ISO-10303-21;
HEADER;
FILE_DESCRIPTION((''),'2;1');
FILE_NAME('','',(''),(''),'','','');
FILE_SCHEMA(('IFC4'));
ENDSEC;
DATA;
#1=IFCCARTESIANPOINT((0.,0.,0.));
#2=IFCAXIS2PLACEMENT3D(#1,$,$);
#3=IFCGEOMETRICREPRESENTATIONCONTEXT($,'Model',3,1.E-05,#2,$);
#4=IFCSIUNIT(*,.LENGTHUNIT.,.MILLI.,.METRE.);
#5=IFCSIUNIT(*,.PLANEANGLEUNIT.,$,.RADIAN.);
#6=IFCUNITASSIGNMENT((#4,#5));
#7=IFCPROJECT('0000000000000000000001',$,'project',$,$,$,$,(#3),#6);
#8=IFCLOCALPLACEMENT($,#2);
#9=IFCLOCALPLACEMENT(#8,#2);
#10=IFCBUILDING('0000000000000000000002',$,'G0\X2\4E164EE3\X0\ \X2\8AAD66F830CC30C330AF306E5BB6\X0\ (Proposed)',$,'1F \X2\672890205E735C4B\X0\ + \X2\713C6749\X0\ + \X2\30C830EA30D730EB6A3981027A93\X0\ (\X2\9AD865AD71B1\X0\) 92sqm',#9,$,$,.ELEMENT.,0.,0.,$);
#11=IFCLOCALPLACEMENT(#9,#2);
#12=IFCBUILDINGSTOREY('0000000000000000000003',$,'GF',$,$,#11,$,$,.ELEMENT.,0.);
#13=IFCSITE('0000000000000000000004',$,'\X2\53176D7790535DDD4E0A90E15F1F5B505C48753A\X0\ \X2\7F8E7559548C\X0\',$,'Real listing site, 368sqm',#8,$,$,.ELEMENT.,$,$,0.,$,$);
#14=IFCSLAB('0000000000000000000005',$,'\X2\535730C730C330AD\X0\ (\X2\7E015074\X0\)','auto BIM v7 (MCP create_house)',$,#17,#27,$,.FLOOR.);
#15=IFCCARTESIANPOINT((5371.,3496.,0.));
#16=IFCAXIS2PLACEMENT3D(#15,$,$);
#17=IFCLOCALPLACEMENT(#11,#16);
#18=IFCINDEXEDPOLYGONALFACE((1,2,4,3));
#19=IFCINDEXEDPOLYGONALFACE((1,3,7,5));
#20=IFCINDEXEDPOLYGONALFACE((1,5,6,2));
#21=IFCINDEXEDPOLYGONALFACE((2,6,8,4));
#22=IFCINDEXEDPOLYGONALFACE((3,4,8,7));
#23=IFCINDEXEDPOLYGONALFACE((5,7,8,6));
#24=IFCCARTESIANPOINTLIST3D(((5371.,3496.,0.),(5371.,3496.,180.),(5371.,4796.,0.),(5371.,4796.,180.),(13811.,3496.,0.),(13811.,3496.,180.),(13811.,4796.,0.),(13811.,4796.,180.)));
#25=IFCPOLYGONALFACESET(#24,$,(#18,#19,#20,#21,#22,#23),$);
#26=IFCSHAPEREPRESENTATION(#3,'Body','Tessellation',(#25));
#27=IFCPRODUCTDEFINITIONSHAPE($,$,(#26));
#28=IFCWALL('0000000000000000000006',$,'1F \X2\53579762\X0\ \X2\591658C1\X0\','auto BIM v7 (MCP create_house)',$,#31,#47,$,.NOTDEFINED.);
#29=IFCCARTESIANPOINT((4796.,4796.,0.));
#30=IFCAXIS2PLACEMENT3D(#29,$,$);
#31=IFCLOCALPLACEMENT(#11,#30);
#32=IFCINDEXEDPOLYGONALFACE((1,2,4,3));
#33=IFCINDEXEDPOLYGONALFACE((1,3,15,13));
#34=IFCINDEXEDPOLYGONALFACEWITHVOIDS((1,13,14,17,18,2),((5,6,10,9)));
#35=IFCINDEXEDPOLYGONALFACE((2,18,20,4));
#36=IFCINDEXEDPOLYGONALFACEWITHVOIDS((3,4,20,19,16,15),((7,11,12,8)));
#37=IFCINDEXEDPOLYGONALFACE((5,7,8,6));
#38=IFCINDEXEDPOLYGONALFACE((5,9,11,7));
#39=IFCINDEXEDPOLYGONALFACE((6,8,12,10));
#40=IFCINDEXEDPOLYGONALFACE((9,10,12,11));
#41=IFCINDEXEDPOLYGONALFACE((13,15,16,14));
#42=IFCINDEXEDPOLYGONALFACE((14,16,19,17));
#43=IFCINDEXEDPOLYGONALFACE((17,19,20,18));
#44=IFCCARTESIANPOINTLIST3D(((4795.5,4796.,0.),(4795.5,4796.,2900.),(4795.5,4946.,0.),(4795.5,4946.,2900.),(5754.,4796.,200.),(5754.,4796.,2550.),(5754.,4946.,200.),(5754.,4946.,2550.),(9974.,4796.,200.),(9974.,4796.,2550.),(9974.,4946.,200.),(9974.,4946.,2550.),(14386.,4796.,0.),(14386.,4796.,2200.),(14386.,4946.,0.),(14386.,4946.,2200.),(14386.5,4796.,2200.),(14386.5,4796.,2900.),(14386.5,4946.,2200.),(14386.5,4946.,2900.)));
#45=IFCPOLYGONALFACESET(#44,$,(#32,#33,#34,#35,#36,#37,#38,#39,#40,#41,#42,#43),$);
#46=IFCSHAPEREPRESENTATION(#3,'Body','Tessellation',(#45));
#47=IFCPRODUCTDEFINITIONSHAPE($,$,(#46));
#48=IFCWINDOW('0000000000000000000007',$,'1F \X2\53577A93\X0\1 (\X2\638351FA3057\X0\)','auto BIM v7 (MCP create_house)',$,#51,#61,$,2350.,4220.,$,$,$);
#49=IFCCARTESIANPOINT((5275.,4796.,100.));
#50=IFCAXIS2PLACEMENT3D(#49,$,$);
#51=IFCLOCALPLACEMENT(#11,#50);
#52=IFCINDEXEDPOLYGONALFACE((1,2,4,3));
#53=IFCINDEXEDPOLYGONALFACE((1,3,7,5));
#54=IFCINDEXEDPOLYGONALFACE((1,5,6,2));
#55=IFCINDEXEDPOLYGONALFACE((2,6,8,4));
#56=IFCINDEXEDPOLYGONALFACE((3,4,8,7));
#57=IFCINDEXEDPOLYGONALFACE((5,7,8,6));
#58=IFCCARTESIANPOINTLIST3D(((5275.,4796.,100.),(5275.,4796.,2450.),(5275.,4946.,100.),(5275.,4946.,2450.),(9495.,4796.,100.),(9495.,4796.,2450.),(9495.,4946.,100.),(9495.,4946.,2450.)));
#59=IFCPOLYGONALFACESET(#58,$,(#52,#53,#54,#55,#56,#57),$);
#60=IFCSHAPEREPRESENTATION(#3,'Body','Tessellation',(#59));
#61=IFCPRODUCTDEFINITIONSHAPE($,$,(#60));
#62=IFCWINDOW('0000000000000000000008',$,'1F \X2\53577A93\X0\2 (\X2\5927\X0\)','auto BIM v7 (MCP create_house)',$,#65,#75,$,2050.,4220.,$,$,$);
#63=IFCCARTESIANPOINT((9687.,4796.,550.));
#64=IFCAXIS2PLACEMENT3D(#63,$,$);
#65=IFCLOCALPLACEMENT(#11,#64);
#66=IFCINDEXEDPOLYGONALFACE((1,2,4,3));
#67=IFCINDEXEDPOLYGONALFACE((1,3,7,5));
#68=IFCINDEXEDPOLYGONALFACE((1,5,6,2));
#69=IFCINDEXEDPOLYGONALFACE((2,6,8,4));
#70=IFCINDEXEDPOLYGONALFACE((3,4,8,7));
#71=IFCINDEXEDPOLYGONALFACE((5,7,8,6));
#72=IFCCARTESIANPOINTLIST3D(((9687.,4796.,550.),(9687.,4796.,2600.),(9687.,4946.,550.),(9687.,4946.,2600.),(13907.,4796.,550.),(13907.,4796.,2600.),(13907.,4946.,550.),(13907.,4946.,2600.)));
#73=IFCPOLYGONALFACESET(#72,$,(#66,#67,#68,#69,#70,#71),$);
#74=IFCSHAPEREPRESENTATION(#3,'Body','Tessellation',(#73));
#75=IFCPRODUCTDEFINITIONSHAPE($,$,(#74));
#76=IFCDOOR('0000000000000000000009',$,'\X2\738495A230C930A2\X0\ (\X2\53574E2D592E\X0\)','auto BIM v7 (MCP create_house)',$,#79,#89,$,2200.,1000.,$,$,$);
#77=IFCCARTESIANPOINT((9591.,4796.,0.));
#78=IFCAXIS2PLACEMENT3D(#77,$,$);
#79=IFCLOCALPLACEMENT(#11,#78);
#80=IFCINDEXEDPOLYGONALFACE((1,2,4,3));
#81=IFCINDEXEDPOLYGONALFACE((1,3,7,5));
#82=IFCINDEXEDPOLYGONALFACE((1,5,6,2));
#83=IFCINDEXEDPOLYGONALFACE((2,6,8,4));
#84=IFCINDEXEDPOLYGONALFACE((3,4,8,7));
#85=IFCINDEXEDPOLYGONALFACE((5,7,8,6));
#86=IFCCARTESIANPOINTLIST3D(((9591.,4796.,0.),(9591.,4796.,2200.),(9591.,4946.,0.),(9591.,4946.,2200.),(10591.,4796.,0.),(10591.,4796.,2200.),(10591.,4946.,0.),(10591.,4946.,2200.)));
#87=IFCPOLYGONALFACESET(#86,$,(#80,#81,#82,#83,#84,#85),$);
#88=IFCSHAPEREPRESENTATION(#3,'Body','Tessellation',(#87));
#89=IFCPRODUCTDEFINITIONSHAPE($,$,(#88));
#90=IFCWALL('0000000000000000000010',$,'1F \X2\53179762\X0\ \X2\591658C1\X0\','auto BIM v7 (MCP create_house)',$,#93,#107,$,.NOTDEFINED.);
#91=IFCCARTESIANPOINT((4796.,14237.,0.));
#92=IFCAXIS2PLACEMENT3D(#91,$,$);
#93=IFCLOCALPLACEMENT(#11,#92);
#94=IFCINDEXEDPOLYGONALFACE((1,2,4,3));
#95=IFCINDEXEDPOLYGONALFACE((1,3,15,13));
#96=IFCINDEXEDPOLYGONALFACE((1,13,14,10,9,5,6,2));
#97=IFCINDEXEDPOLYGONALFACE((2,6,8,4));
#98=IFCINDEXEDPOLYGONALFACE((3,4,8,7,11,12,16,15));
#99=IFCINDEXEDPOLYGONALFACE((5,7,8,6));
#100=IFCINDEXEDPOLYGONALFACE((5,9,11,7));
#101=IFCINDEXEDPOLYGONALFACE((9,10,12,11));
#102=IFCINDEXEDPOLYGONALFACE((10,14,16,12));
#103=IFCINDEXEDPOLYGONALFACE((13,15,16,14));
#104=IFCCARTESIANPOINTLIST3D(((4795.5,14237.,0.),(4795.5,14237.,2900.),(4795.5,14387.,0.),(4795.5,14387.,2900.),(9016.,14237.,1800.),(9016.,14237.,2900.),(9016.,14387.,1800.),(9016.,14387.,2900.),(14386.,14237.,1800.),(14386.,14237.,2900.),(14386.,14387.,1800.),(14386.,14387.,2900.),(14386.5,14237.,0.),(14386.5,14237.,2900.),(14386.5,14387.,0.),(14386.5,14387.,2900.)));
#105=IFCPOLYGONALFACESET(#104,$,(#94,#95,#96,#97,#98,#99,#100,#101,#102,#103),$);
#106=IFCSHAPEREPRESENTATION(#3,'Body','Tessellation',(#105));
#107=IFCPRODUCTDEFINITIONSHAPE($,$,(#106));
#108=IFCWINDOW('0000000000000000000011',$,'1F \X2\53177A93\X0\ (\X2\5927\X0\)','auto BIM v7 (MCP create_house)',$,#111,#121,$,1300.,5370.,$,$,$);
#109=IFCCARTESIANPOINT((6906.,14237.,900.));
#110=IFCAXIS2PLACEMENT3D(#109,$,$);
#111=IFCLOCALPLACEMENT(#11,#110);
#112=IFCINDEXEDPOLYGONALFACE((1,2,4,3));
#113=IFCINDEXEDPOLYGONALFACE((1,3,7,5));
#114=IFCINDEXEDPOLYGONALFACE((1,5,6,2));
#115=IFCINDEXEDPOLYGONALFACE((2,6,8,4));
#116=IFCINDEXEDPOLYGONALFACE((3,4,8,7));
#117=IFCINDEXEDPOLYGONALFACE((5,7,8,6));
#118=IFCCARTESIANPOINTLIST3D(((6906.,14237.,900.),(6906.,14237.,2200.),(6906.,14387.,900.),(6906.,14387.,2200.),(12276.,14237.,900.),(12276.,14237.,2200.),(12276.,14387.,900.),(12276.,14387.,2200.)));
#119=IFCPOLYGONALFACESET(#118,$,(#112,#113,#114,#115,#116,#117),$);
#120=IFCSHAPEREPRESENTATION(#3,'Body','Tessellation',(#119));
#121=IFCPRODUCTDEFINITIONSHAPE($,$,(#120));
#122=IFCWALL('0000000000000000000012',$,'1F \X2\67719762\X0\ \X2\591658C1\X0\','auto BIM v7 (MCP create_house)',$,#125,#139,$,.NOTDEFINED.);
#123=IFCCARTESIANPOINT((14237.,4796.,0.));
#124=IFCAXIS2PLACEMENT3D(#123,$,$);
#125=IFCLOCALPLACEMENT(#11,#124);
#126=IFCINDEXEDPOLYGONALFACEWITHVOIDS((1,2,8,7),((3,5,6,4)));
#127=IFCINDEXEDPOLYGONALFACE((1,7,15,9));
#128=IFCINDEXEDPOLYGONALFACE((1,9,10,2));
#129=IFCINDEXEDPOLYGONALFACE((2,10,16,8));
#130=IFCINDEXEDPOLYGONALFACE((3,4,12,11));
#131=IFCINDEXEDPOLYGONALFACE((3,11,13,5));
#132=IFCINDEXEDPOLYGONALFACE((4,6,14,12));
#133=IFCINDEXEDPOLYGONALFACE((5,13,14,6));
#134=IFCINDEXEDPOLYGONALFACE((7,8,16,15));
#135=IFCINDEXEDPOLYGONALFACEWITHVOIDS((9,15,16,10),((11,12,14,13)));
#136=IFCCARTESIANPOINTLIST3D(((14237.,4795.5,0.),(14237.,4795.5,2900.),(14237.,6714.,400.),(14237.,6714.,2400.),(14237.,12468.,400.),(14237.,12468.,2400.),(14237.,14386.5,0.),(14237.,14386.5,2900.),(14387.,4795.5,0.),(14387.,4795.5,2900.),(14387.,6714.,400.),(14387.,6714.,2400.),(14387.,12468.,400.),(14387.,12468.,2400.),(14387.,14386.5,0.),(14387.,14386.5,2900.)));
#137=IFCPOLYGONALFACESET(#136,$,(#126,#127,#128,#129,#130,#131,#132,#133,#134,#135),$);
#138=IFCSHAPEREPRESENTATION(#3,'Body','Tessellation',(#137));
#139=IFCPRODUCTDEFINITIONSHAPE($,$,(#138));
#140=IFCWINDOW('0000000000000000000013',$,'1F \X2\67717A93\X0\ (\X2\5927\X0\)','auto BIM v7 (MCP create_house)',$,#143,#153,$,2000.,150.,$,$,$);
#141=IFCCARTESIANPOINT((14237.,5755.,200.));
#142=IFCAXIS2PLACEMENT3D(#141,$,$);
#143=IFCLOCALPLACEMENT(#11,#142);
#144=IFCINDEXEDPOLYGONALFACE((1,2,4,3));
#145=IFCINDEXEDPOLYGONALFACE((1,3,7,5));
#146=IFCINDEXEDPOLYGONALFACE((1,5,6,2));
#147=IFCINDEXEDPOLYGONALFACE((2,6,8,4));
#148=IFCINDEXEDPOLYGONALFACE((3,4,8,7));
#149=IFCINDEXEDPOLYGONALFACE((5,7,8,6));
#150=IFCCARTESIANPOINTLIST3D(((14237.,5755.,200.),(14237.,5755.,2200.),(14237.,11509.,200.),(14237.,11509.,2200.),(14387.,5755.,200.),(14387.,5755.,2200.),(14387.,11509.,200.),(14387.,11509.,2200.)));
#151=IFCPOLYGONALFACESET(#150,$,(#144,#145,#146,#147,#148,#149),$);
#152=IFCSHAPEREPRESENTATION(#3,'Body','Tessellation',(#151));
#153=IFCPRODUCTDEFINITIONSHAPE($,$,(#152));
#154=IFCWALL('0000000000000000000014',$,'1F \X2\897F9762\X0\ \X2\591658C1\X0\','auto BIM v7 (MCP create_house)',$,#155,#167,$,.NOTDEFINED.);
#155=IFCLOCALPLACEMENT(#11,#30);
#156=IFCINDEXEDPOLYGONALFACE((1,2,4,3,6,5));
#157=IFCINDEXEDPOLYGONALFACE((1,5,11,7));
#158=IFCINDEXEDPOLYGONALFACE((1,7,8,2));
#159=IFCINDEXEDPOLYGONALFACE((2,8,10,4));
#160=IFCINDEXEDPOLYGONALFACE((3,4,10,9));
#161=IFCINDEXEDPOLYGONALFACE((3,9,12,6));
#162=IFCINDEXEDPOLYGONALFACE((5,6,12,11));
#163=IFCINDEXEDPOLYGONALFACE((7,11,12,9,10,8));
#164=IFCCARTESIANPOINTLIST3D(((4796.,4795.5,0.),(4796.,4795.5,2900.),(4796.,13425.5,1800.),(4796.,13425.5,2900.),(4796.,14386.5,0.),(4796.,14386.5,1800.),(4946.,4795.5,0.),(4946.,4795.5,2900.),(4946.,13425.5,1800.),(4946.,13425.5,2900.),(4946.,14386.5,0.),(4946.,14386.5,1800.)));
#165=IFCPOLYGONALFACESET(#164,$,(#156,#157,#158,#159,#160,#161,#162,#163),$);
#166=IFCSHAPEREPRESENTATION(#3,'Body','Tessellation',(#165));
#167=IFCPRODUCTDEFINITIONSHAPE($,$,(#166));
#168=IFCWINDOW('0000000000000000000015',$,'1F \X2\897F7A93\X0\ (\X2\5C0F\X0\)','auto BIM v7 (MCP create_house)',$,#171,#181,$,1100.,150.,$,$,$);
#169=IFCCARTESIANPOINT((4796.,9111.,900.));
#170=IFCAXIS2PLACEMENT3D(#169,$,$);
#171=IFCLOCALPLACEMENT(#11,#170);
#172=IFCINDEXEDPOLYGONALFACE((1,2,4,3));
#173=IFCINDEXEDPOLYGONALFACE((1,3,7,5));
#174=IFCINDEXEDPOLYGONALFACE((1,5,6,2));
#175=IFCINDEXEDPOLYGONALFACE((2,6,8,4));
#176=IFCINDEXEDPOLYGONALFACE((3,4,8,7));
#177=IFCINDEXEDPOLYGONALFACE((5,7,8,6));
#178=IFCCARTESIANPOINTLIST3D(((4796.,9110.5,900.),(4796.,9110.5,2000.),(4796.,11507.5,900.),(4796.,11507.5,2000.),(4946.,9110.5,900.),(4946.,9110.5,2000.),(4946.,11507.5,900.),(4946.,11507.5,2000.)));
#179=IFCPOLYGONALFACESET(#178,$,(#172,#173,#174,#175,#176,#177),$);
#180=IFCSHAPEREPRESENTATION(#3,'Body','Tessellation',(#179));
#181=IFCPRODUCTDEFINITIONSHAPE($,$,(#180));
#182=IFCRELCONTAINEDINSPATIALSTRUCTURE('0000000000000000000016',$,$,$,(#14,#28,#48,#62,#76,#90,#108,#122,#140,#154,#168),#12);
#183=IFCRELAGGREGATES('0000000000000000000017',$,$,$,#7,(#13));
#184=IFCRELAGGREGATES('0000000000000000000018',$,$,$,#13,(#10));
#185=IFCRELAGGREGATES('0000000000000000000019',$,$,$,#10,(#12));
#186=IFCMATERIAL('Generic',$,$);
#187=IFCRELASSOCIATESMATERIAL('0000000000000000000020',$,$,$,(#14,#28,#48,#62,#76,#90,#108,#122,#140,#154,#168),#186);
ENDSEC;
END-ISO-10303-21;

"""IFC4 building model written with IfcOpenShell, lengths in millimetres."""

from ifc_helpers import new_model, si_unit, frame, frame_2d, origin, place, context, project, spatial, rectangle, extrude, material, element, fill, save


model = new_model("IFC4")

# Units and contexts
model_context = context("Model", 3, precision=1e-05, world=origin())
ifc_project = project(units=[si_unit("LENGTHUNIT", "METRE", prefix="MILLI"), si_unit("PLANEANGLEUNIT", "RADIAN")], contexts=[model_context])

# Site, building, storey
site_placement = place(None, origin())
site = spatial("IfcSite", under=ifc_project, at=site_placement, Name="北海道川上郡弟子屈町 美留和", ObjectType="Real listing site, 368sqm", CompositionType="ELEMENT", RefElevation=0.0)
building_placement = place(site_placement, origin())
building = spatial("IfcBuilding", under=site, at=building_placement, Name="G0世代 読書ヌックの家 (Proposed)", ObjectType="1F 木造平屋 + 焼杉 + トリプル樹脂窓 (高断熱) 92sqm", CompositionType="ELEMENT", ElevationOfRefHeight=0.0, ElevationOfTerrain=0.0)
storey_placement = place(building_placement, origin())
storey = spatial("IfcBuildingStorey", under=building, at=storey_placement, Name="GF", CompositionType="ELEMENT", Elevation=0.0)

# Slab
ifc_material = material(Name="Generic")
slab_1_placement = place(storey_placement, frame((5371.0, 3496.0, 0.0)))
element("IfcSlab", 1, at=slab_1_placement, inside=storey, material=ifc_material, Name="南デッキ (縁側)", Description="auto BIM v7 (MCP create_house)", PredefinedType="FLOOR", context=model_context, shape_type="SweptSolid", body=[
    extrude(rectangle(XDim=8440.0, YDim=1300.0, at=frame_2d((4220.0, 650.0))), frame((5371.0, 3496.0, 0.0)), (0.0, 0.0, 1.0), 180.0),
])

# Wall, openings, windows, door
wall_1_placement = place(storey_placement, frame((4796.0, 4796.0, 0.0)))
wall_1 = element("IfcWall", 2, at=wall_1_placement, inside=storey, material=ifc_material, Name="1F 南面 外壁", Description="auto BIM v7 (MCP create_house)", PredefinedType="NOTDEFINED", context=model_context, shape_type="SweptSolid", body=[
    extrude(rectangle(XDim=9591.0, YDim=150.0, at=frame_2d((4795.0, 75.0))), frame((4796.0, 4796.0, 0.0)), (0.0, 0.0, 1.0), 2900.0),
])
opening_1_placement = place(storey_placement, frame((5275.0, 4796.0, 100.0)))
opening_1 = element("IfcOpeningElement", 3, at=opening_1_placement, cuts=wall_1, PredefinedType="NOTDEFINED", context=model_context, shape_type="SweptSolid", body=[
    extrude(rectangle(XDim=4220.0, YDim=150.0, at=frame_2d((2110.0, 75.0))), frame((5275.0, 4796.0, 100.0)), (0.0, 0.0, 1.0), 2350.0),
])
opening_2_placement = place(storey_placement, frame((9687.0, 4796.0, 550.0)))
opening_2 = element("IfcOpeningElement", 4, at=opening_2_placement, cuts=wall_1, PredefinedType="NOTDEFINED", context=model_context, shape_type="SweptSolid", body=[
    extrude(rectangle(XDim=4220.0, YDim=150.0, at=frame_2d((2110.0, 75.0))), frame((9687.0, 4796.0, 550.0)), (0.0, 0.0, 1.0), 2050.0),
])
opening_3_placement = place(storey_placement, frame((9591.0, 4796.0, 0.0)))
opening_3 = element("IfcOpeningElement", 5, at=opening_3_placement, cuts=wall_1, PredefinedType="NOTDEFINED", context=model_context, shape_type="SweptSolid", body=[
    extrude(rectangle(XDim=1000.0, YDim=150.0, at=frame_2d((500.0, 75.0))), frame((9591.0, 4796.0, 0.0)), (0.0, 0.0, 1.0), 2200.0),
])
window_1_placement = place(storey_placement, frame((5275.0, 4796.0, 100.0)))
window_1 = element("IfcWindow", 6, at=window_1_placement, inside=storey, material=ifc_material, Name="1F 南窓1 (掃出し)", Description="auto BIM v7 (MCP create_house)", OverallHeight=2350.0, OverallWidth=4220.0, context=model_context, shape_type="SweptSolid", body=[
    extrude(rectangle(XDim=4220.0, YDim=150.0, at=frame_2d((2110.0, 75.0))), frame((5275.0, 4796.0, 100.0)), (0.0, 0.0, 1.0), 2350.0),
])
fill(opening_1, window_1)
window_2_placement = place(storey_placement, frame((9687.0, 4796.0, 550.0)))
window_2 = element("IfcWindow", 7, at=window_2_placement, inside=storey, material=ifc_material, Name="1F 南窓2 (大)", Description="auto BIM v7 (MCP create_house)", OverallHeight=2050.0, OverallWidth=4220.0, context=model_context, shape_type="SweptSolid", body=[
    extrude(rectangle(XDim=4220.0, YDim=150.0, at=frame_2d((2110.0, 75.0))), frame((9687.0, 4796.0, 550.0)), (0.0, 0.0, 1.0), 2050.0),
])
fill(opening_2, window_2)
door_placement = place(storey_placement, frame((9591.0, 4796.0, 0.0)))
door = element("IfcDoor", 8, at=door_placement, inside=storey, material=ifc_material, Name="玄関ドア (南中央)", Description="auto BIM v7 (MCP create_house)", OverallHeight=2200.0, OverallWidth=1000.0, context=model_context, shape_type="SweptSolid", body=[
    extrude(rectangle(XDim=1000.0, YDim=150.0, at=frame_2d((500.0, 75.0))), frame((9591.0, 4796.0, 0.0)), (0.0, 0.0, 1.0), 2200.0),
])
fill(opening_3, door)

# Walls, openings, windows
wall_2_placement = place(storey_placement, frame((4796.0, 14237.0, 0.0)))
wall_2 = element("IfcWall", 9, at=wall_2_placement, inside=storey, material=ifc_material, Name="1F 北面 外壁", Description="auto BIM v7 (MCP create_house)", PredefinedType="NOTDEFINED", context=model_context, shape_type="SweptSolid", body=[
    extrude(rectangle(XDim=9591.0, YDim=150.0, at=frame_2d((4795.0, 75.0))), frame((4796.0, 14237.0, 0.0)), (0.0, 0.0, 1.0), 2900.0),
])
opening_4_placement = place(storey_placement, frame((6906.0, 14237.0, 900.0)))
opening_4 = element("IfcOpeningElement", 10, at=opening_4_placement, cuts=wall_2, PredefinedType="NOTDEFINED", context=model_context, shape_type="SweptSolid", body=[
    extrude(rectangle(XDim=5370.0, YDim=150.0, at=frame_2d((2685.0, 75.0))), frame((6906.0, 14237.0, 900.0)), (0.0, 0.0, 1.0), 1300.0),
])
window_3_placement = place(storey_placement, frame((6906.0, 14237.0, 900.0)))
window_3 = element("IfcWindow", 11, at=window_3_placement, inside=storey, material=ifc_material, Name="1F 北窓 (大)", Description="auto BIM v7 (MCP create_house)", OverallHeight=1300.0, OverallWidth=5370.0, context=model_context, shape_type="SweptSolid", body=[
    extrude(rectangle(XDim=5370.0, YDim=150.0, at=frame_2d((2685.0, 75.0))), frame((6906.0, 14237.0, 900.0)), (0.0, 0.0, 1.0), 1300.0),
])
fill(opening_4, window_3)
wall_3_placement = place(storey_placement, frame((14237.0, 4796.0, 0.0)))
wall_3 = element("IfcWall", 12, at=wall_3_placement, inside=storey, material=ifc_material, Name="1F 東面 外壁", Description="auto BIM v7 (MCP create_house)", PredefinedType="NOTDEFINED", context=model_context, shape_type="SweptSolid", body=[
    extrude(rectangle(XDim=150.0, YDim=9591.0, at=frame_2d((75.0, 4795.0))), frame((14237.0, 4796.0, 0.0)), (0.0, 0.0, 1.0), 2900.0),
])
opening_5_placement = place(storey_placement, frame((14237.0, 5755.0, 200.0)))
opening_5 = element("IfcOpeningElement", 13, at=opening_5_placement, cuts=wall_3, PredefinedType="NOTDEFINED", context=model_context, shape_type="SweptSolid", body=[
    extrude(rectangle(XDim=150.0, YDim=5754.0, at=frame_2d((75.0, 2877.0))), frame((14237.0, 5755.0, 200.0)), (0.0, 0.0, 1.0), 2000.0),
])
window_4_placement = place(storey_placement, frame((14237.0, 5755.0, 200.0)))
window_4 = element("IfcWindow", 14, at=window_4_placement, inside=storey, material=ifc_material, Name="1F 東窓 (大)", Description="auto BIM v7 (MCP create_house)", OverallHeight=2000.0, OverallWidth=150.0, context=model_context, shape_type="SweptSolid", body=[
    extrude(rectangle(XDim=150.0, YDim=5754.0, at=frame_2d((75.0, 2877.0))), frame((14237.0, 5755.0, 200.0)), (0.0, 0.0, 1.0), 2000.0),
])
fill(opening_5, window_4)
wall_4_placement = place(storey_placement, frame((4796.0, 4796.0, 0.0)))
wall_4 = element("IfcWall", 15, at=wall_4_placement, inside=storey, material=ifc_material, Name="1F 西面 外壁", Description="auto BIM v7 (MCP create_house)", PredefinedType="NOTDEFINED", context=model_context, shape_type="SweptSolid", body=[
    extrude(rectangle(XDim=150.0, YDim=9591.0, at=frame_2d((75.0, 4795.0))), frame((4796.0, 4796.0, 0.0)), (0.0, 0.0, 1.0), 2900.0),
])
opening_6_placement = place(storey_placement, frame((4796.0, 9111.0, 900.0)))
opening_6 = element("IfcOpeningElement", 16, at=opening_6_placement, cuts=wall_4, PredefinedType="NOTDEFINED", context=model_context, shape_type="SweptSolid", body=[
    extrude(rectangle(XDim=150.0, YDim=2397.0, at=frame_2d((75.0, 1198.0))), frame((4796.0, 9111.0, 900.0)), (0.0, 0.0, 1.0), 1100.0),
])
window_5_placement = place(storey_placement, frame((4796.0, 9111.0, 900.0)))
window_5 = element("IfcWindow", 17, at=window_5_placement, inside=storey, material=ifc_material, Name="1F 西窓 (小)", Description="auto BIM v7 (MCP create_house)", OverallHeight=1100.0, OverallWidth=150.0, context=model_context, shape_type="SweptSolid", body=[
    extrude(rectangle(XDim=150.0, YDim=2397.0, at=frame_2d((75.0, 1198.0))), frame((4796.0, 9111.0, 900.0)), (0.0, 0.0, 1.0), 1100.0),
])
fill(opening_6, window_5)

save(model, "model.ifc")
